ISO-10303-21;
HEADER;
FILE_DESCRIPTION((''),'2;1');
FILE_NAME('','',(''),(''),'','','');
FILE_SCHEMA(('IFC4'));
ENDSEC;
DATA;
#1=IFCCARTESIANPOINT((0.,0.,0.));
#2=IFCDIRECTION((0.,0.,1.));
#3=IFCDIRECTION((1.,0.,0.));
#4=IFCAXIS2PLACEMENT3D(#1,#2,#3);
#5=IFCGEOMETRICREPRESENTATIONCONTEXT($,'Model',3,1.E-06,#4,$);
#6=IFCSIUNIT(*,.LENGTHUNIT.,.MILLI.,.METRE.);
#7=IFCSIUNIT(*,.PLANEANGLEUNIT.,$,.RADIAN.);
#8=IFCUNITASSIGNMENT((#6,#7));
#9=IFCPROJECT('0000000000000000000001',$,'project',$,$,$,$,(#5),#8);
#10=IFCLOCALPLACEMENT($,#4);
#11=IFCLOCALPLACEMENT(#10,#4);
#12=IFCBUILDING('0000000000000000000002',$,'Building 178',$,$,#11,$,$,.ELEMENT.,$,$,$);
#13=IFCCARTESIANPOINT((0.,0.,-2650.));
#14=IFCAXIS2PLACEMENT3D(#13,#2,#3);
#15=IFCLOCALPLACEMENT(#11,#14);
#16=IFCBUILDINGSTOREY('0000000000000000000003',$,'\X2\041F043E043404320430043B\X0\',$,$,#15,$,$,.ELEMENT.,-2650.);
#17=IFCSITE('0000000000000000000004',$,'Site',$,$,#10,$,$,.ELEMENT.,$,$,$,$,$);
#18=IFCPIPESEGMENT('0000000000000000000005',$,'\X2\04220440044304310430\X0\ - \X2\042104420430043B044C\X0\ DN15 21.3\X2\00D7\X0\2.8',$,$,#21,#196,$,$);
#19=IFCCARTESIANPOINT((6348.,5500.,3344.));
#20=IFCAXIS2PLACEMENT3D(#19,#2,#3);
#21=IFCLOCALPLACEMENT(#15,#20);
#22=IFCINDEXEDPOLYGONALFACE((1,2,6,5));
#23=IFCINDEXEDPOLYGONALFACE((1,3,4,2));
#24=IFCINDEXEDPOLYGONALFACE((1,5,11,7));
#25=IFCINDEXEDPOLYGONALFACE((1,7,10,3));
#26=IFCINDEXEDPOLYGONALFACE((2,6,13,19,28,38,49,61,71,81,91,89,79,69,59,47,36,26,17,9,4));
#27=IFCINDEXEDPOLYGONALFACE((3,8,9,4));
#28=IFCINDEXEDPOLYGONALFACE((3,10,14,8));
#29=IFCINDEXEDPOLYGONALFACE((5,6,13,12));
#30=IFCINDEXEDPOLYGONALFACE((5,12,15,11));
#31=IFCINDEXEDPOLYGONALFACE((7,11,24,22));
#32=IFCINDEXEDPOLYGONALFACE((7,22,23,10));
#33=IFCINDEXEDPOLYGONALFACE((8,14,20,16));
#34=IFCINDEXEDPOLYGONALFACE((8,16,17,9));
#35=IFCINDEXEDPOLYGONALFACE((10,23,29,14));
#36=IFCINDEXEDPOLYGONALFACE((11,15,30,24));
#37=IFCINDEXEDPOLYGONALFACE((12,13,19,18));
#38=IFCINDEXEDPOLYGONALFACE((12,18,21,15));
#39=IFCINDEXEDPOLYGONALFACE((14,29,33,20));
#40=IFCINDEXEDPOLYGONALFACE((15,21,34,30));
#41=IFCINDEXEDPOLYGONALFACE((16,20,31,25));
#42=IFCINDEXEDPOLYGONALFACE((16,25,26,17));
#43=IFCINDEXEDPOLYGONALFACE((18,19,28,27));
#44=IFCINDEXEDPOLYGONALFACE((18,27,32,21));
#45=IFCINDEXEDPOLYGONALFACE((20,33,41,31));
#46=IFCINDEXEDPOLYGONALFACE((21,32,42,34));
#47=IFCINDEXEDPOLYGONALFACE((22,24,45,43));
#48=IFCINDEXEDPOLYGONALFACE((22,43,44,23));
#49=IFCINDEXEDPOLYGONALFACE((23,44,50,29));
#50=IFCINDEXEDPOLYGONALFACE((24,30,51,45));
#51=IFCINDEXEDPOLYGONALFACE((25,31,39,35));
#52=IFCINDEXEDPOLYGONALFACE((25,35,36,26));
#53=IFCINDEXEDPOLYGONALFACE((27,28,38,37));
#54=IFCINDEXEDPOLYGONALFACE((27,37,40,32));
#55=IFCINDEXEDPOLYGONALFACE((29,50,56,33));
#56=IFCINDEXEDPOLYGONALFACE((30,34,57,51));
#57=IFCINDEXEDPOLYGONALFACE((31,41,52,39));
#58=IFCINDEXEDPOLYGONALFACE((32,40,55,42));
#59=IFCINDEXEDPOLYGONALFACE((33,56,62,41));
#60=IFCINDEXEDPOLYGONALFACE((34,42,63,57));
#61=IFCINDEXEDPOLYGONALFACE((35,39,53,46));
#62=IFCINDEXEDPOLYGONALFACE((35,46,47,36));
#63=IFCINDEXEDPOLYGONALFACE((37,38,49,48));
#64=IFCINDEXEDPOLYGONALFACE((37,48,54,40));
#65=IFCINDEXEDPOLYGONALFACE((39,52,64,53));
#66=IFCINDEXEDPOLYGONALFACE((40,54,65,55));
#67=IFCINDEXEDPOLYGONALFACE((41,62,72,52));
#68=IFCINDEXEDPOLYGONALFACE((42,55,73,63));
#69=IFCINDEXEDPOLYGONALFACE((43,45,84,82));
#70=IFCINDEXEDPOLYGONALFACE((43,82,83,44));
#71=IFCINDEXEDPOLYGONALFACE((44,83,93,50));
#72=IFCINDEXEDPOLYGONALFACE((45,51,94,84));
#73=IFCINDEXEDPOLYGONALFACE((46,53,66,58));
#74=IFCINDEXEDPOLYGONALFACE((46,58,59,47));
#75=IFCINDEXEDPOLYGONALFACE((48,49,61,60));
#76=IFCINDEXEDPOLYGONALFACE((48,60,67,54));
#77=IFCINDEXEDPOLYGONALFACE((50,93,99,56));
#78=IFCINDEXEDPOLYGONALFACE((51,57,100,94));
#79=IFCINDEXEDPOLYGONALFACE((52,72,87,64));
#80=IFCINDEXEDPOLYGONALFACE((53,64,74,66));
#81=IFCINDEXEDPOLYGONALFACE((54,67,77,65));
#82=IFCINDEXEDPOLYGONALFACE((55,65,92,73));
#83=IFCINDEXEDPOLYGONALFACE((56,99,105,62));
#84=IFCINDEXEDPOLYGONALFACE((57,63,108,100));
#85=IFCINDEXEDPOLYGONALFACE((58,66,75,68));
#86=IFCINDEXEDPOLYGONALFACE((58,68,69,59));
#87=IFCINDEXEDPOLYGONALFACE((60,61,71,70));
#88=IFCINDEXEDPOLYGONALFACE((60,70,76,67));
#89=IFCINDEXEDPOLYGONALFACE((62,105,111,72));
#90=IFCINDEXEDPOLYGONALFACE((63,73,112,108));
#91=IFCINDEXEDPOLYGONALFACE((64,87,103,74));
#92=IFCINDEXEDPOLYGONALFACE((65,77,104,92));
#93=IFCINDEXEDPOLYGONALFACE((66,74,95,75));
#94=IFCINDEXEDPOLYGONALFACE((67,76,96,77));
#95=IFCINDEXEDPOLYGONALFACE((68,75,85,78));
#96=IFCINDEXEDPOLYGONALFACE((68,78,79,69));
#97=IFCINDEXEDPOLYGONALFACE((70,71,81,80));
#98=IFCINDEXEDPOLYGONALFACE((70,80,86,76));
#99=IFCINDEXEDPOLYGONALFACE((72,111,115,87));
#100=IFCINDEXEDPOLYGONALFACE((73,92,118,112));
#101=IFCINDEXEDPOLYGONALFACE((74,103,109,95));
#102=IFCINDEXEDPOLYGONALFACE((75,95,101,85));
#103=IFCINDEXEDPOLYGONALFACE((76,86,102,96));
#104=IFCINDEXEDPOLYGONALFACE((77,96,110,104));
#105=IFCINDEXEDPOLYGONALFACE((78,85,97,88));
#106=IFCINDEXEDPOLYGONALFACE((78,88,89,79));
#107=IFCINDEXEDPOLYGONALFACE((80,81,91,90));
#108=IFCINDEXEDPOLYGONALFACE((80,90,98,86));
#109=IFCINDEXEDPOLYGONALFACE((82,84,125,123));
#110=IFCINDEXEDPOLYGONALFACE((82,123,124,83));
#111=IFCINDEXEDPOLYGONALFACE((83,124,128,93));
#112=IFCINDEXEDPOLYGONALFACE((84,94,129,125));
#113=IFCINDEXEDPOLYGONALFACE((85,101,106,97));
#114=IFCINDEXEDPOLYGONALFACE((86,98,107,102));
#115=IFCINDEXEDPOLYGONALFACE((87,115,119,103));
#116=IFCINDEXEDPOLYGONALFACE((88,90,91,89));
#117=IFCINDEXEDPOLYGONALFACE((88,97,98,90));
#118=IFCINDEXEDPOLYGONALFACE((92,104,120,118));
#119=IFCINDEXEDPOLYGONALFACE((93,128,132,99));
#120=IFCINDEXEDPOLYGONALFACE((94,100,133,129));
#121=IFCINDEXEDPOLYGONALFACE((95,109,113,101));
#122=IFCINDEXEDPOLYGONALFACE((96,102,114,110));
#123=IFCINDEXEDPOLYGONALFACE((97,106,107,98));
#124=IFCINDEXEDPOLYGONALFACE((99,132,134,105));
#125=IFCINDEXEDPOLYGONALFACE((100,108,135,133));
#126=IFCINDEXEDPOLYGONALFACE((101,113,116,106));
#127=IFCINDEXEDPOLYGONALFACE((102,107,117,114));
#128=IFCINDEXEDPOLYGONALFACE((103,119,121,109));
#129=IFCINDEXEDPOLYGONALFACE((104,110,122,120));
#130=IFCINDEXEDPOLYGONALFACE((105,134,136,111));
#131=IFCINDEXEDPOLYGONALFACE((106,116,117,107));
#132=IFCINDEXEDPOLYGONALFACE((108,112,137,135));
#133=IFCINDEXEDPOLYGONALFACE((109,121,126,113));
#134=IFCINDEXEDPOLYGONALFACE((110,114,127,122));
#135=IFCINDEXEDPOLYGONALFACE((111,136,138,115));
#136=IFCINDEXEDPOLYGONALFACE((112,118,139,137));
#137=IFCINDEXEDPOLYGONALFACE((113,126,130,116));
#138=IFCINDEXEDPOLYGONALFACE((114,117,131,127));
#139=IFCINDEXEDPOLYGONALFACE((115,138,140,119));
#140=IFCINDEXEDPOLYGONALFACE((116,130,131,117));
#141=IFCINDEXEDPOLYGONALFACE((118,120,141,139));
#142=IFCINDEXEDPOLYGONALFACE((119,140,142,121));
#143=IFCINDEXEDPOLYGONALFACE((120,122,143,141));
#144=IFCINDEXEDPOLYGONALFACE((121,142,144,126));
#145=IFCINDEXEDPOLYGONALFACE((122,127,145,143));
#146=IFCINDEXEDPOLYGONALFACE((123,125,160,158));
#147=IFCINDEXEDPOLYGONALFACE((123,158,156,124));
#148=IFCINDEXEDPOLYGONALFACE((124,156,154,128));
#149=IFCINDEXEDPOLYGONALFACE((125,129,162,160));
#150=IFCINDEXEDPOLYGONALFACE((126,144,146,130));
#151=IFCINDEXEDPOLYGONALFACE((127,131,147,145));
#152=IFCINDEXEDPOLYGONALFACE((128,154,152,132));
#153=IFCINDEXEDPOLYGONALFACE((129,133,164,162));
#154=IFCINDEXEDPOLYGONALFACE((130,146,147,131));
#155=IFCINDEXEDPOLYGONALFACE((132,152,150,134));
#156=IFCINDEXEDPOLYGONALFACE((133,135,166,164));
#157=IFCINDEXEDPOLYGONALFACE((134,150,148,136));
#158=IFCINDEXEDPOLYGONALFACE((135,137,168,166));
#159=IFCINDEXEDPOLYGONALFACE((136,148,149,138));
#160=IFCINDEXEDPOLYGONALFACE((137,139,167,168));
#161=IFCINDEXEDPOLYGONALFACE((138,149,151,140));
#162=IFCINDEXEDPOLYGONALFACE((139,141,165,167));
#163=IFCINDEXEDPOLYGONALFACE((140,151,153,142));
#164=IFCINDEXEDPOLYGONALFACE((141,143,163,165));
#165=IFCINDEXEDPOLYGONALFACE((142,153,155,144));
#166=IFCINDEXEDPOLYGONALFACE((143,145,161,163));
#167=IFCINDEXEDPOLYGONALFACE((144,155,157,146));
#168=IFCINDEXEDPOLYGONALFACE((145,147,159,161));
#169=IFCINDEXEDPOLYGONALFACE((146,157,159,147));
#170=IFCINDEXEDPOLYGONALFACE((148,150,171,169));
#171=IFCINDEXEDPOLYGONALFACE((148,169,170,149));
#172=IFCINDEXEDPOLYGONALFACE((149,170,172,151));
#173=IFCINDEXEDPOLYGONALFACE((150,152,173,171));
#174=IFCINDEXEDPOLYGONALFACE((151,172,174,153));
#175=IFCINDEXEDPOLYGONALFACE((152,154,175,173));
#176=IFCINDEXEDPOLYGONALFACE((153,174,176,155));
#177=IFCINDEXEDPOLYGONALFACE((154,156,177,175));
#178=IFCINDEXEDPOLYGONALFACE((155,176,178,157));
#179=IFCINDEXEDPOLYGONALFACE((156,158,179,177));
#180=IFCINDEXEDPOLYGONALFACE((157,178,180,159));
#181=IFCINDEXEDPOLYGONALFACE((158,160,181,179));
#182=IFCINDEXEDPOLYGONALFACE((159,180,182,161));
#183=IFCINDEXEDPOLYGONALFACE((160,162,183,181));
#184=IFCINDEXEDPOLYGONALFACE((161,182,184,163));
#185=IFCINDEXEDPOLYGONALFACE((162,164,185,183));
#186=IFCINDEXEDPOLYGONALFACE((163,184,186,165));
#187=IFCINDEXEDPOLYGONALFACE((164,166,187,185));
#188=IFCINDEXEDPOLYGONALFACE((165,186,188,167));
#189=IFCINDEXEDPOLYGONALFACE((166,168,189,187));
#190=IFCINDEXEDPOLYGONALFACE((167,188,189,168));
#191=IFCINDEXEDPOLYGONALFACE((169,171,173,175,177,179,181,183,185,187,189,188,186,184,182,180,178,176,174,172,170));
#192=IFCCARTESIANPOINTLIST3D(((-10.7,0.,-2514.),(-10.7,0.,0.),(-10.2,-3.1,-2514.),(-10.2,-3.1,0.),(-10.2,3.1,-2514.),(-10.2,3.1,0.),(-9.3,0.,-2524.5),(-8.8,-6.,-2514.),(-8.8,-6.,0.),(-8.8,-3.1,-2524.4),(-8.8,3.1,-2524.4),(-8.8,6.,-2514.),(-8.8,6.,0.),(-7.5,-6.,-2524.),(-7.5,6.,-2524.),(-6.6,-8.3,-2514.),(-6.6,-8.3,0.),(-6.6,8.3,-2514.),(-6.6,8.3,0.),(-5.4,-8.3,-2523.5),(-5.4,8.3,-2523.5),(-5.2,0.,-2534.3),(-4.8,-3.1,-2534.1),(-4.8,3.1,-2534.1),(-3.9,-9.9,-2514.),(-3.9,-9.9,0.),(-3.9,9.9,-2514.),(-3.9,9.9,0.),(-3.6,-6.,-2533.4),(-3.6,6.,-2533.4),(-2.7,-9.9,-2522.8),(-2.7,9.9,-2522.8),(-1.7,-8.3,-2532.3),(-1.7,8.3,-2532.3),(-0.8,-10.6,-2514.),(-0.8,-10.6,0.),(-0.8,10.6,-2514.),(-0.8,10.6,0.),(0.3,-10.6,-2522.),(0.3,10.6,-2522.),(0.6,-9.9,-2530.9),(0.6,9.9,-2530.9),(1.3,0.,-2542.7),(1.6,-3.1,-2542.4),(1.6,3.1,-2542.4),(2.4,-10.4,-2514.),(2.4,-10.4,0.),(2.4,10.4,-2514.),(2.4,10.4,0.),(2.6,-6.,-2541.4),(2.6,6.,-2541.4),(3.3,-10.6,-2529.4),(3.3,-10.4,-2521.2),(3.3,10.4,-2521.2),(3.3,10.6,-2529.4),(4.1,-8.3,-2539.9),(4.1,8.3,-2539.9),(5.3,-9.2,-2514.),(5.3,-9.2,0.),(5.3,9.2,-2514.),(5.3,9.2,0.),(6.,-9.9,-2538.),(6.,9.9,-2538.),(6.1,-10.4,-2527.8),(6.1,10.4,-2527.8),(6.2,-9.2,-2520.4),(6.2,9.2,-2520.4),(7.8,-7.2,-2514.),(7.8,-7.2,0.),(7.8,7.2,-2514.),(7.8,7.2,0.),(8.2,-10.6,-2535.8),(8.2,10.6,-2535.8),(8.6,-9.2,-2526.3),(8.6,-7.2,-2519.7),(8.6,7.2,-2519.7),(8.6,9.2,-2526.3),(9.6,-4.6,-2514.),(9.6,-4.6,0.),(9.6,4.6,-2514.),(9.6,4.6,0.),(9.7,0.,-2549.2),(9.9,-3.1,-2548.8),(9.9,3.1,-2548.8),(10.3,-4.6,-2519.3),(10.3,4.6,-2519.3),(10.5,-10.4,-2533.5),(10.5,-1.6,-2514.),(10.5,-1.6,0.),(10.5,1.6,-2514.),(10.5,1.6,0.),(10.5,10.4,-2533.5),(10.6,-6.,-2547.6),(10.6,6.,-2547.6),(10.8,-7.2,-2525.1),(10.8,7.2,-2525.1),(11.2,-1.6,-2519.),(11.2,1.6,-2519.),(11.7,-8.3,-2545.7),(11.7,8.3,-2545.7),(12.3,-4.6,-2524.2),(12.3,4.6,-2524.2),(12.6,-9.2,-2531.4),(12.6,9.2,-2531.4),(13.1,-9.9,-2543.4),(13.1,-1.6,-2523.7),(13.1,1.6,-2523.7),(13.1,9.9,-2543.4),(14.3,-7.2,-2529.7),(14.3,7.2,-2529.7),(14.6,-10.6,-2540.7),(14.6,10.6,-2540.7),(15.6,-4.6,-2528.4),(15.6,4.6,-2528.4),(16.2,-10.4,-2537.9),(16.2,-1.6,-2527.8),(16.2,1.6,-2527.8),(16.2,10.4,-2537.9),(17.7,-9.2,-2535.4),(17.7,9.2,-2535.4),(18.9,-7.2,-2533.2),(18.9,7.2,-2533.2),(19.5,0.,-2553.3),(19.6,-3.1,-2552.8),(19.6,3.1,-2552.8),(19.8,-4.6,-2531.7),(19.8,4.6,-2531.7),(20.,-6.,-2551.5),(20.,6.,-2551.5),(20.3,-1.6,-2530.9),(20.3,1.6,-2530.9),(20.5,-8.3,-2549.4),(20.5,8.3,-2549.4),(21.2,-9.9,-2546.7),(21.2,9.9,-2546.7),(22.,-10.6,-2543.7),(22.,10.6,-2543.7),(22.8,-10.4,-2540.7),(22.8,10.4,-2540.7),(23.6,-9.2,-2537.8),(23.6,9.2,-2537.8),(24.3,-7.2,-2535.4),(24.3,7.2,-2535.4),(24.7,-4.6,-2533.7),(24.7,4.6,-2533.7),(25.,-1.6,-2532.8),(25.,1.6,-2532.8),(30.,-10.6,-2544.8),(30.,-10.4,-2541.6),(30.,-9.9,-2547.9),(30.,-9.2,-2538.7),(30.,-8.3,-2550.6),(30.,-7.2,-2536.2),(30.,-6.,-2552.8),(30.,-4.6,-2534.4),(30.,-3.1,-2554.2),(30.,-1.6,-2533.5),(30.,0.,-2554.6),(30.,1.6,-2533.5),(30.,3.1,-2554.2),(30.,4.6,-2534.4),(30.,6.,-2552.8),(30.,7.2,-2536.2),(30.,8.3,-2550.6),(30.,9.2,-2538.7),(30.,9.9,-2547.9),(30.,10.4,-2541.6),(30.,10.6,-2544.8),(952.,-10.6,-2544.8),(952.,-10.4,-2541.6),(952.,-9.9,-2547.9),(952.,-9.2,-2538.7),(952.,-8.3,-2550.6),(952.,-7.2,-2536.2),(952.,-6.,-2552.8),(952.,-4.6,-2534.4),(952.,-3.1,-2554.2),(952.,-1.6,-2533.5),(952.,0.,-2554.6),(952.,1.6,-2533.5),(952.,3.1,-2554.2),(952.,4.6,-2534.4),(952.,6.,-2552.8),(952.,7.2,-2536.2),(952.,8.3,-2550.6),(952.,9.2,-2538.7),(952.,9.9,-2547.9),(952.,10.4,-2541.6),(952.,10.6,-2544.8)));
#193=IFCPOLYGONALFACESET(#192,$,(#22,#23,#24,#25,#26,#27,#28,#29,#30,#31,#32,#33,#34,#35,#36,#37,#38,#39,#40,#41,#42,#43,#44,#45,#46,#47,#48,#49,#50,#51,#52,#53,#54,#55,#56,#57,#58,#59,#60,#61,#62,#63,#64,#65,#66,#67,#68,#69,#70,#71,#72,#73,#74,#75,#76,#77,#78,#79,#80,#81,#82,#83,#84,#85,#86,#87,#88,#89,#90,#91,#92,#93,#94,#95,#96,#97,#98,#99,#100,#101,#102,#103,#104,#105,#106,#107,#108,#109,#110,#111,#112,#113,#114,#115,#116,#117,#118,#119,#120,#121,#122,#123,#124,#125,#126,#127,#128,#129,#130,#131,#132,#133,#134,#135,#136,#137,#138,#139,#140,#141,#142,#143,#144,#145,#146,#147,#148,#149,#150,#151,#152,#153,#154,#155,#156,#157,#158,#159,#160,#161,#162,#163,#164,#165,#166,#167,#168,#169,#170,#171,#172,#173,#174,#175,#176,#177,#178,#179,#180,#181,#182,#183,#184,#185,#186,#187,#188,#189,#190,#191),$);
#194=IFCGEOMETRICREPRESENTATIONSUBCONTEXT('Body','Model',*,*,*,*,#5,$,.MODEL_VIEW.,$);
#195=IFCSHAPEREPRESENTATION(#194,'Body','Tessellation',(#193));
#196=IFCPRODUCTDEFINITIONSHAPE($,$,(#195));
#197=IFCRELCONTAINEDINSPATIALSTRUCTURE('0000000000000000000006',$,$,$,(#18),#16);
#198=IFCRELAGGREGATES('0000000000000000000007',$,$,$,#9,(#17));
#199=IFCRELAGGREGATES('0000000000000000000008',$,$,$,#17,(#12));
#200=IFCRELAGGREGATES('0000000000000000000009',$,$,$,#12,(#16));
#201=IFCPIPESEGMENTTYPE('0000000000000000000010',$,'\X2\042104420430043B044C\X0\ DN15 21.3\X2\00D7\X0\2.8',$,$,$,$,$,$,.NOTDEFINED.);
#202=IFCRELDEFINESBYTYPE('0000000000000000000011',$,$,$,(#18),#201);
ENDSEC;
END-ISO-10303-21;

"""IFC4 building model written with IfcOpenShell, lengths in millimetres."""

from ifc_helpers import new_model, entity, si_unit, frame, origin_with_axes, place, context, subcontext, project, spatial, source, transform, mapped, type_object, element, save


model = new_model("IFC4")

# Units and contexts
model_context = context("Model", 3, precision=1e-06, world=origin_with_axes())
body_context = subcontext(model_context, "Body", "Model", "MODEL_VIEW")
ifc_project = project(units=[si_unit("LENGTHUNIT", "METRE", prefix="MILLI"), si_unit("PLANEANGLEUNIT", "RADIAN")], contexts=[model_context])

# Site, building, storey
site_placement = place(None, origin_with_axes())
site = spatial("IfcSite", under=ifc_project, at=site_placement, Name="Site", CompositionType="ELEMENT")
building_placement = place(site_placement, origin_with_axes())
building = spatial("IfcBuilding", under=site, at=building_placement, Name="Building 178", CompositionType="ELEMENT")
storey_placement = place(building_placement, frame((0.0, 0.0, -2650.0), z_axis=(0.0, 0.0, 1.0), x_axis=(1.0, 0.0, 0.0)))
storey = spatial("IfcBuildingStorey", under=building, at=storey_placement, Name="Подвал", CompositionType="ELEMENT", Elevation=-2650.0)

# Pipe segment
pipe_segment_type_1 = type_object("IfcPipeSegmentType", Name="Сталь DN15 21.3×2.8", PredefinedType="NOTDEFINED")
shared_shape_1 = source(origin_with_axes(), body_context, "Body", "AdvancedSweptSolid", [
    entity("IfcSweptDiskSolid", entity("IfcIndexedPolyCurve", entity("IfcCartesianPointList3D", [[0.0, 0.0, 0.0], [0.0, 0.0, -2514.0], [8.8, 0.0, -2535.2], [30.0, 0.0, -2544.0], [952.0, 0.0, -2544.0]]), [entity("IfcLineIndex", [1, 2]), entity("IfcArcIndex", [2, 3, 4]), entity("IfcLineIndex", [4, 5])]), 10.7),
])
pipe_segment_1_placement = place(storey_placement, frame((6348.0, 5500.0, 3344.0), z_axis=(0.0, 0.0, 1.0), x_axis=(1.0, 0.0, 0.0)))
element("IfcPipeSegment", 1, at=pipe_segment_1_placement, inside=storey, type_object=pipe_segment_type_1, Name="Труба - Сталь DN15 21.3×2.8", context=body_context, shape_type="MappedRepresentation", body=[
    mapped(shared_shape_1, transform((0.0, 0.0, 0.0), x_axis=(1.0, 0.0, 0.0), y_axis=(0.0, 1.0, 0.0), z_axis=(0.0, 0.0, 1.0), scale=1.0)),
])

save(model, "model.ifc")
